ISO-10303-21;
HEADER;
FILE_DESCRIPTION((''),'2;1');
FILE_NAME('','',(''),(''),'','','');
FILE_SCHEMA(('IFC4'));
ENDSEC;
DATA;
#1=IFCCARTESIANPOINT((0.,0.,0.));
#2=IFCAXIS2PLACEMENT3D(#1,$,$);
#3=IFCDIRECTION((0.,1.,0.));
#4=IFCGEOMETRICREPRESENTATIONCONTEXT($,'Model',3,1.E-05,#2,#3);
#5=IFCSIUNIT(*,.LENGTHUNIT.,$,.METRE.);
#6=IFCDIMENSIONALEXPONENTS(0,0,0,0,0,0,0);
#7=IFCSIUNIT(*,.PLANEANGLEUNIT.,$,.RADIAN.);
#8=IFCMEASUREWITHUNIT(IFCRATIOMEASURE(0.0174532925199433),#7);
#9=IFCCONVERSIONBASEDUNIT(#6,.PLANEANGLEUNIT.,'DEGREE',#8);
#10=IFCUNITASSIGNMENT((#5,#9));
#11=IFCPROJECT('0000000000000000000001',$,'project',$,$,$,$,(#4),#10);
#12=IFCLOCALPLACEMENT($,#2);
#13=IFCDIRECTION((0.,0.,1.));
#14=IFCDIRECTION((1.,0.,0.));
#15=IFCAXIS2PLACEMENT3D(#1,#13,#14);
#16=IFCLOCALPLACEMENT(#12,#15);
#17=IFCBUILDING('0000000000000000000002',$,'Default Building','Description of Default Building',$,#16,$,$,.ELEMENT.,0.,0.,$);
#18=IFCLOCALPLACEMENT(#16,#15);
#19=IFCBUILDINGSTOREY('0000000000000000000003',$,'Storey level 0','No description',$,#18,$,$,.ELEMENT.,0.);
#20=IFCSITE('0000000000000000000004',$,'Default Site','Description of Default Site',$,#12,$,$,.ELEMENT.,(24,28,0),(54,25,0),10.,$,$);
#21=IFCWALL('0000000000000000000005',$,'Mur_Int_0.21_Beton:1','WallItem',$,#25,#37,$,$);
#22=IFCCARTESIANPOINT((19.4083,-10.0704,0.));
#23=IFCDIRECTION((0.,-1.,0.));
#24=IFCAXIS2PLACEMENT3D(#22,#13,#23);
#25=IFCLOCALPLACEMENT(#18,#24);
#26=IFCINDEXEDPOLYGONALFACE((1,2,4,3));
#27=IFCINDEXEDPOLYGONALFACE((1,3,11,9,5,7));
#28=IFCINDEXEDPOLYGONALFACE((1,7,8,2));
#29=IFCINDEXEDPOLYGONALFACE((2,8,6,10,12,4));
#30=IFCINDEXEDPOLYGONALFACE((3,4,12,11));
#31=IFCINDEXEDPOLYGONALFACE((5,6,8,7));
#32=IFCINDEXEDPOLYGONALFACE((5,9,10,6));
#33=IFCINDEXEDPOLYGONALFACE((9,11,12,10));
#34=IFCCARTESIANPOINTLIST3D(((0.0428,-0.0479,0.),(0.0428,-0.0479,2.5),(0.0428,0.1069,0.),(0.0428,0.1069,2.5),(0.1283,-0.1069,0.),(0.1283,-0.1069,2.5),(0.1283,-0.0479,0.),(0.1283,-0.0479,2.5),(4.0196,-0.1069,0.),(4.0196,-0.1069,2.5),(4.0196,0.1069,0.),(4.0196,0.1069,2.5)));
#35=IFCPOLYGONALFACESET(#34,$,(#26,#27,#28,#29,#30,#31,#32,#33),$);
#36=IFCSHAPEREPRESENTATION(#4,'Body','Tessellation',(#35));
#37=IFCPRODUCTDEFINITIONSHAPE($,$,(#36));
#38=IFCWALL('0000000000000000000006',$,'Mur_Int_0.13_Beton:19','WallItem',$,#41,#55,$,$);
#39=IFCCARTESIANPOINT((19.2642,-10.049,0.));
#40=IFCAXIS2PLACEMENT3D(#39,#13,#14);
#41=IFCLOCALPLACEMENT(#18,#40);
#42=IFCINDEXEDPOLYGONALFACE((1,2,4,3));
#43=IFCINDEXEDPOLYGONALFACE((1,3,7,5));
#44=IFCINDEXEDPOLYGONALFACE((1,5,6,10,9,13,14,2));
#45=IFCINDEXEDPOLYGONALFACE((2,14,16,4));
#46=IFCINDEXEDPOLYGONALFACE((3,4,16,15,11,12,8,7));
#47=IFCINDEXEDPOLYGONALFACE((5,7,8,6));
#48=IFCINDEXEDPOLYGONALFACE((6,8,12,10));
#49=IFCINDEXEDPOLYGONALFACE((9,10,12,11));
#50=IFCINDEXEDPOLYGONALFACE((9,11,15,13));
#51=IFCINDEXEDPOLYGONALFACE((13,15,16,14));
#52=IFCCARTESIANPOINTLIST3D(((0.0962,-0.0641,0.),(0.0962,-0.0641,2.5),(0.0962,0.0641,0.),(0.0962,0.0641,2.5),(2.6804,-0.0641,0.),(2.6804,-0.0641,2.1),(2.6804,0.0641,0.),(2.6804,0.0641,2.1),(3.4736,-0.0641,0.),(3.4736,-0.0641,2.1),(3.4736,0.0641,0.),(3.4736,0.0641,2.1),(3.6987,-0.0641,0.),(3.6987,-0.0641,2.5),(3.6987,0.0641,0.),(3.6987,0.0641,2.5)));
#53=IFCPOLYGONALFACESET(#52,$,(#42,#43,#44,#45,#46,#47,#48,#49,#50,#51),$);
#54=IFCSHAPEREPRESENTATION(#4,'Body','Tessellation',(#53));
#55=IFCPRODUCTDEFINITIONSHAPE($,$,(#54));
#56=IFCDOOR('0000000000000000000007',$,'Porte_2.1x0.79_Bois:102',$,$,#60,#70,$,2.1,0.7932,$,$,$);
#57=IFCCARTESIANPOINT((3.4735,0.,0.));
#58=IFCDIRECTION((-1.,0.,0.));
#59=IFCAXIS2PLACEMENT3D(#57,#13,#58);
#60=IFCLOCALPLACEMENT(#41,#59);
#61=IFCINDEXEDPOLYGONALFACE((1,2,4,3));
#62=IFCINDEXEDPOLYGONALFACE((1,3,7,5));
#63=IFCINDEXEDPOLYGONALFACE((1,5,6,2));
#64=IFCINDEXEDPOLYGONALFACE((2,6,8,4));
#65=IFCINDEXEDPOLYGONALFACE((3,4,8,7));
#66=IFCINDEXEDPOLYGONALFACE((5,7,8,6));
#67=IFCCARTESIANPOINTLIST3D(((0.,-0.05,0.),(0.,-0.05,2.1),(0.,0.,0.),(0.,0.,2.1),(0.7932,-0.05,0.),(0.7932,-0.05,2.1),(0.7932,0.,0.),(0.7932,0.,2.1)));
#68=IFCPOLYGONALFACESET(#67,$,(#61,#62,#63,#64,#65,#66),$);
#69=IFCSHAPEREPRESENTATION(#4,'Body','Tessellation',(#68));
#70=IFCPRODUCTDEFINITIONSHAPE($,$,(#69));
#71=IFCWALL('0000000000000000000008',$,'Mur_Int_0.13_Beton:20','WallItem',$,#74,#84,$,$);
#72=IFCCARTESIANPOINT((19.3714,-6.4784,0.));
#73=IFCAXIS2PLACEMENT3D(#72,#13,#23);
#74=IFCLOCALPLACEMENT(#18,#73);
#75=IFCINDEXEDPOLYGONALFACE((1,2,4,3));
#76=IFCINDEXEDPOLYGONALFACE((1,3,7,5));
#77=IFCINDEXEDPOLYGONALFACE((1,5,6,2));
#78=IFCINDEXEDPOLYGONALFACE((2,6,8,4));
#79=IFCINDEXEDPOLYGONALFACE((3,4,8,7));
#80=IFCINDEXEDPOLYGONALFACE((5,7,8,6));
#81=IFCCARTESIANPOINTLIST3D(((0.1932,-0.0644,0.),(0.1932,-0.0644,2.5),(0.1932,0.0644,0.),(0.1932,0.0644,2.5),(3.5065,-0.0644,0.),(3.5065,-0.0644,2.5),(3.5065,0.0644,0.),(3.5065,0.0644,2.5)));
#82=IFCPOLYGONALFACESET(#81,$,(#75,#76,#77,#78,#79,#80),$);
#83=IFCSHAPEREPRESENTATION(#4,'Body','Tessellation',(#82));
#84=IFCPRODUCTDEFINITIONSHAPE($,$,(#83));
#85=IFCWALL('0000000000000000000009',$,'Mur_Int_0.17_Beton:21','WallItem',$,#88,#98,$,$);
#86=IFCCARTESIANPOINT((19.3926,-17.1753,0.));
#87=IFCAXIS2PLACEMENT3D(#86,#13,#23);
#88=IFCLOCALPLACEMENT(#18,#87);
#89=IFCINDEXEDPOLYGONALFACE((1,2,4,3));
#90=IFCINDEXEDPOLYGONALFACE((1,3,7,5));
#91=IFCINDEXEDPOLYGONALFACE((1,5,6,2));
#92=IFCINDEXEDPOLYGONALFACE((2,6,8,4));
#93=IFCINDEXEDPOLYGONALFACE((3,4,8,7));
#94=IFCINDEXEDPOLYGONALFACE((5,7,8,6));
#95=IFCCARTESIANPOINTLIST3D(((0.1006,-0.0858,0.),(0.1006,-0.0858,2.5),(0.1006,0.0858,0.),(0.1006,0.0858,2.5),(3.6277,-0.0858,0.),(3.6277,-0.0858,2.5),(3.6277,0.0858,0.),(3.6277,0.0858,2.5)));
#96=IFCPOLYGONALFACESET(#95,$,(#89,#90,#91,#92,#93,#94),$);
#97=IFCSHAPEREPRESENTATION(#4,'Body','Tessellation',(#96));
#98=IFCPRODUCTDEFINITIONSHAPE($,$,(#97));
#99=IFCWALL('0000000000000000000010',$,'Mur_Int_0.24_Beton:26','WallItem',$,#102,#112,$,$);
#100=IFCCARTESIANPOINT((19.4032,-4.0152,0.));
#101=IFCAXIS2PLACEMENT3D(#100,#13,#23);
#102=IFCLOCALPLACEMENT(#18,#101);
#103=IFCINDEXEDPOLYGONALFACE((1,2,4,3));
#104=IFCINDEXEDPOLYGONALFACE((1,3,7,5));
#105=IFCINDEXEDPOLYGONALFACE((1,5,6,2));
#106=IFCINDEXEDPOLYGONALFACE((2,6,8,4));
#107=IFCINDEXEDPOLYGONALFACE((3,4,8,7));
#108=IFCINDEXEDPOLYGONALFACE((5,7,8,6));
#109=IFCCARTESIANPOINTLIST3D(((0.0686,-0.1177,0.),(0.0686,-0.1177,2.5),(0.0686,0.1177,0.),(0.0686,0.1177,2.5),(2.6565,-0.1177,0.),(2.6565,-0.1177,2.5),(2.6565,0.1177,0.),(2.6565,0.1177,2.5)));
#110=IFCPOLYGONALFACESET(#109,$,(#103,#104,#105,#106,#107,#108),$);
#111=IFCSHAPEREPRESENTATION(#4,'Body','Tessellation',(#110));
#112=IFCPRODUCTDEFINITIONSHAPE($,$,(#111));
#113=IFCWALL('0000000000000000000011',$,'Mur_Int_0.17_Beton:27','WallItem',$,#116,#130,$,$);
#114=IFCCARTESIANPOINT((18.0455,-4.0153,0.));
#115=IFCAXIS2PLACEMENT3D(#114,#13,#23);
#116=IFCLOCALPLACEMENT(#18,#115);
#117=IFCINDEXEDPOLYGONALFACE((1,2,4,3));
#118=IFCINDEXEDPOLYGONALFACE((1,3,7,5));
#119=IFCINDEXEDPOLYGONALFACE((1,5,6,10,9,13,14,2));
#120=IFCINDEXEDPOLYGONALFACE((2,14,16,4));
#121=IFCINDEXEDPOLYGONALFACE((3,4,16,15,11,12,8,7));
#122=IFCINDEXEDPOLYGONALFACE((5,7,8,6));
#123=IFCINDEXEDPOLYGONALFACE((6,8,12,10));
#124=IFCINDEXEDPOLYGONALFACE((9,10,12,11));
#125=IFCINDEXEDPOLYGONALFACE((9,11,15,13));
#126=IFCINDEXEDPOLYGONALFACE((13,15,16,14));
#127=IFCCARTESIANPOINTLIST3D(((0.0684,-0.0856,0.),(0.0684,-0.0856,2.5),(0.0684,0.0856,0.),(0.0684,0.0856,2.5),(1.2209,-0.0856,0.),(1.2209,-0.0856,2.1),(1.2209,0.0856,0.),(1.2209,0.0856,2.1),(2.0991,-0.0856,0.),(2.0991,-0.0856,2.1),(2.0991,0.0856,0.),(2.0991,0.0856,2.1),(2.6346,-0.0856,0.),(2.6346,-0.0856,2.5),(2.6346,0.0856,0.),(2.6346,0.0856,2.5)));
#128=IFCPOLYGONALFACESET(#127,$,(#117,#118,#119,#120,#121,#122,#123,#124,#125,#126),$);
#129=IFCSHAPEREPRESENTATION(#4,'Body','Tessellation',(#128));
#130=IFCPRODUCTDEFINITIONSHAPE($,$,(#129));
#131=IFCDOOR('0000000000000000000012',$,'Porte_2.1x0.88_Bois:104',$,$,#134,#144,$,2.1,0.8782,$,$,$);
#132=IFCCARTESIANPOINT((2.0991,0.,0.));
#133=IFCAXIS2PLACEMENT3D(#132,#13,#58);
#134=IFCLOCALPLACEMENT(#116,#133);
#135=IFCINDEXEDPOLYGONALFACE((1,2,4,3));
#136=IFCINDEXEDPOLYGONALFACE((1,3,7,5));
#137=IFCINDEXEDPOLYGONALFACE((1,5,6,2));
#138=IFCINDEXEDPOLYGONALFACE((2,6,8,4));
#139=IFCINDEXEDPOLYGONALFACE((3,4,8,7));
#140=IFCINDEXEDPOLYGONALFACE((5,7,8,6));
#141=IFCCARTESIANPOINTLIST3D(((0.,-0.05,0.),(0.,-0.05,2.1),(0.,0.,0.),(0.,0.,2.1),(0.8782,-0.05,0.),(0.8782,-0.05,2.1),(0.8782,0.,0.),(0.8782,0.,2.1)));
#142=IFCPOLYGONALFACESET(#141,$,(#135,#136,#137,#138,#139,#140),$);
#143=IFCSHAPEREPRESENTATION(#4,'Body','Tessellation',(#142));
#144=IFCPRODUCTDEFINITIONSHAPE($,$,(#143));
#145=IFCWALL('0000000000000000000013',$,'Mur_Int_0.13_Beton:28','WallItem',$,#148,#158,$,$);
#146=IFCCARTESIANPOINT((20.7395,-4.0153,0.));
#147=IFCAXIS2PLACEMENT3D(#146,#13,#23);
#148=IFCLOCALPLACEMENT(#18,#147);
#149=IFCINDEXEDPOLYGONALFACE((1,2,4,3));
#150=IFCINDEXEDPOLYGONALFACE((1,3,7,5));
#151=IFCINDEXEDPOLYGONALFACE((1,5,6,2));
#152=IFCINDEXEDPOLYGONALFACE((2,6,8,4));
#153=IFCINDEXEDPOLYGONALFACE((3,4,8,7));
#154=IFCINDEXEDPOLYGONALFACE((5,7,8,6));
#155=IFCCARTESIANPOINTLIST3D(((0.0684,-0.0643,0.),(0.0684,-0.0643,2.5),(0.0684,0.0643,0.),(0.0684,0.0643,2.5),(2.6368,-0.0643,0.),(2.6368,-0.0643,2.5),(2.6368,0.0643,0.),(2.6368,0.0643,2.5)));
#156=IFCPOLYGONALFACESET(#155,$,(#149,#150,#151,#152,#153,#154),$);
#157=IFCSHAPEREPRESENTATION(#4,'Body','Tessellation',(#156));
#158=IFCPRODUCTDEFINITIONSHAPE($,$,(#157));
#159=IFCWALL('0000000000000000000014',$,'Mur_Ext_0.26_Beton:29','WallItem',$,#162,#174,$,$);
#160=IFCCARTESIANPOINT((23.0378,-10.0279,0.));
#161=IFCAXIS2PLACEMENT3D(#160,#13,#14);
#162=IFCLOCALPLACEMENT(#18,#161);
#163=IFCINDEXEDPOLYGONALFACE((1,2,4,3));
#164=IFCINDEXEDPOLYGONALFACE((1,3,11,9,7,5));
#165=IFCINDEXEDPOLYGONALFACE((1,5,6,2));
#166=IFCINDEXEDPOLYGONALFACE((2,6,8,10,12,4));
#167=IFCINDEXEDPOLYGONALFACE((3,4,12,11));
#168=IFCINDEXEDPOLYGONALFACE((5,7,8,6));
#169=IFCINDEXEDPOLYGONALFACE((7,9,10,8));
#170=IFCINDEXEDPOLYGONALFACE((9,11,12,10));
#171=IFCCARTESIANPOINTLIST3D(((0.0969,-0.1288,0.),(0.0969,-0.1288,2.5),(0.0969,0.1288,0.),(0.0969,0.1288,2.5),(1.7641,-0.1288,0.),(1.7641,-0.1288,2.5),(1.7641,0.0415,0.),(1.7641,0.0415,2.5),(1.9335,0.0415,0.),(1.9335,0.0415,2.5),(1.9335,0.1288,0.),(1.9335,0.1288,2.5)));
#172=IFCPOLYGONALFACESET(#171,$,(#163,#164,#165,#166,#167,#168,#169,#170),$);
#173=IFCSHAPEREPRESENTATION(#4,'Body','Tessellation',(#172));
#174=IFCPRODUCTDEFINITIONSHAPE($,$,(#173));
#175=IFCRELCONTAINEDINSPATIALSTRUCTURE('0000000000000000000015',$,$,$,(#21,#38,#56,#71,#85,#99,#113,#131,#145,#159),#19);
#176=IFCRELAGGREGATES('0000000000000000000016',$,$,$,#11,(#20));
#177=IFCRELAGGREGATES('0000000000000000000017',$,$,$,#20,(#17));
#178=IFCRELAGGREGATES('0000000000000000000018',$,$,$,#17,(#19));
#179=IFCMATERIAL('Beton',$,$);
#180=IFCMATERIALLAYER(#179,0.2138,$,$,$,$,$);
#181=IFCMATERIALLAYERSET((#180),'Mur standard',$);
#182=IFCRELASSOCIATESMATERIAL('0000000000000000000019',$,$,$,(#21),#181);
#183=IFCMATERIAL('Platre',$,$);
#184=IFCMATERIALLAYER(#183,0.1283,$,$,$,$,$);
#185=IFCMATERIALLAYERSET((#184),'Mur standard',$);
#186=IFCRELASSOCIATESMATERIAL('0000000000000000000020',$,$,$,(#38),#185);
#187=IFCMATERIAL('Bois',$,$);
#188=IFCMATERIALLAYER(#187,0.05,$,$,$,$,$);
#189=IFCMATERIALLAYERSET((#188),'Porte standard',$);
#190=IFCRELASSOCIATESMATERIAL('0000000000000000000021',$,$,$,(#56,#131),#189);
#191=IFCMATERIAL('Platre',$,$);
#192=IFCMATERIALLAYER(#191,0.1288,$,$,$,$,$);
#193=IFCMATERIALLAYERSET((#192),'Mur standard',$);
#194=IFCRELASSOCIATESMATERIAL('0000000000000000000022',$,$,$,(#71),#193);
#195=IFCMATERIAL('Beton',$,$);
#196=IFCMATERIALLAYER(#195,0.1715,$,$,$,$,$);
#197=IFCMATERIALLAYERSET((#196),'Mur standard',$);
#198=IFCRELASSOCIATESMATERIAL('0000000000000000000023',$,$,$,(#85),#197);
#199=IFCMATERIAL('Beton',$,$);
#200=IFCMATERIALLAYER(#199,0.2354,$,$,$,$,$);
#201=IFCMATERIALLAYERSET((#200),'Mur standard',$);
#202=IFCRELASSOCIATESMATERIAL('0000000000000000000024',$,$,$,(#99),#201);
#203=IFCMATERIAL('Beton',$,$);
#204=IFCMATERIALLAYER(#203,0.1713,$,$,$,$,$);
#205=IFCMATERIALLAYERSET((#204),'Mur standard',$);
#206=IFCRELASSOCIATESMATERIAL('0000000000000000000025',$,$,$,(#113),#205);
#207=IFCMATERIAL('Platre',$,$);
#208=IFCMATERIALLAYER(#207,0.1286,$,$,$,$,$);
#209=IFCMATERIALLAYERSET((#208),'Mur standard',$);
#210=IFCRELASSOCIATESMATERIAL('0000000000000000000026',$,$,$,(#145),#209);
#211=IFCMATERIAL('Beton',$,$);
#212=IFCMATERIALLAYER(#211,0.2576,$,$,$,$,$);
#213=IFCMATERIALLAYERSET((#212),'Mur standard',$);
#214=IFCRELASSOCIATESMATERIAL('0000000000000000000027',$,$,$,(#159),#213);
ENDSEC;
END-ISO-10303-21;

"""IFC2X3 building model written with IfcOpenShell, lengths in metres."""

from ifc_helpers import new_model, entity, si_unit, converted_unit, direction, frame, origin, origin_with_axes, place, context, project, spatial, polyline, outline, extrude, material, layer, layer_set, layer_usage, element, fill, save


model = new_model("IFC2X3")

# Units and contexts
model_context = context("Model", 3, precision=1e-05, world=origin(), true_north=direction((0.0, 1.0, 0.0)))
ifc_project = project(units=[si_unit("LENGTHUNIT", "METRE"), converted_unit("PLANEANGLEUNIT", "DEGREE", entity("IfcRatioMeasure", 0.0174532925199433), si_unit("PLANEANGLEUNIT", "RADIAN"), dimensions=[0, 0, 0, 0, 0, 0, 0])], contexts=[model_context])

# Site, building, storey
site_placement = place(None, origin())
site = spatial("IfcSite", under=ifc_project, at=site_placement, Name="Default Site", Description="Description of Default Site", CompositionType="ELEMENT", RefLatitude=(24, 28, 0), RefLongitude=(54, 25, 0), RefElevation=10.0)
building_placement = place(site_placement, origin_with_axes())
building = spatial("IfcBuilding", under=site, at=building_placement, Name="Default Building", Description="Description of Default Building", CompositionType="ELEMENT", ElevationOfRefHeight=0.0, ElevationOfTerrain=0.0)
storey_placement = place(building_placement, origin_with_axes())
storey = spatial("IfcBuildingStorey", under=building, at=storey_placement, Name="Storey level 0", Description="No description", CompositionType="ELEMENT", Elevation=0.0)

# Wall
ifc_material_1 = material(Name="Beton")
ifc_layer_1 = layer(ifc_material_1, 0.2138)
ifc_layer_set_1 = layer_set([ifc_layer_1], Name="Mur standard")
ifc_layer_usage_1 = layer_usage(ifc_layer_set_1, "AXIS2", "NEGATIVE", 0.2138)
wall_1_placement = place(storey_placement, frame((19.4083, -10.0704, 0.0), z_axis=(0.0, 0.0, 1.0), x_axis=(0.0, -1.0, 0.0)))
element("IfcWall", 1, at=wall_1_placement, inside=storey, material=ifc_layer_usage_1, Name="Mur_Int_0.21_Beton:1", Description="WallItem", context=model_context, shape_type="SweptSolid", body=[
    extrude(outline(polyline([(4.0196, 0.1069), (4.0196, -0.1069), (0.1283, -0.1069), (0.1283, -0.0479), (0.0428, -0.0479), (0.0428, 0.1069), (4.0196, 0.1069)])), origin(), (0.0, 0.0, 1.0), 2.5),
])

# Shared definitions
ifc_material_2 = material(Name="Bois")
ifc_layer_2 = layer(ifc_material_2, 0.05)
ifc_layer_set_2 = layer_set([ifc_layer_2], Name="Porte standard")
ifc_layer_usage_2 = layer_usage(ifc_layer_set_2, "AXIS2", "NEGATIVE", 0.05)

# Wall, opening, door
ifc_material_3 = material(Name="Platre")
ifc_layer_3 = layer(ifc_material_3, 0.1283)
ifc_layer_set_3 = layer_set([ifc_layer_3], Name="Mur standard")
ifc_layer_usage_3 = layer_usage(ifc_layer_set_3, "AXIS2", "NEGATIVE", 0.1283)
wall_2_placement = place(storey_placement, frame((19.2642, -10.049, 0.0), z_axis=(0.0, 0.0, 1.0), x_axis=(1.0, 0.0, 0.0)))
wall_2 = element("IfcWall", 2, at=wall_2_placement, inside=storey, material=ifc_layer_usage_3, Name="Mur_Int_0.13_Beton:19", Description="WallItem", context=model_context, shape_type="SweptSolid", body=[
    extrude(outline(polyline([(0.0962, 0.0641), (0.0962, -0.0641), (3.6987, -0.0641), (3.6987, 0.0641), (0.0962, 0.0641)])), origin(), (0.0, 0.0, 1.0), 2.5),
])
opening_1_placement = place(storey_placement, frame((22.7378, -9.9849, 0.0), z_axis=(0.0, 0.0, 1.0), x_axis=(-1.0, 0.0, 0.0)))
opening_1 = element("IfcOpeningElement", 3, at=opening_1_placement, cuts=wall_2, context=model_context, shape_type="SweptSolid", body=[
    extrude(outline(polyline([(0.7932, 0.1783), (0.0, 0.1783), (0.0, -0.05), (0.7932, -0.05), (0.7932, 0.1783)])), origin(), (0.0, 0.0, 1.0), 2.1),
])
door_1_placement = place(wall_2_placement, frame((3.4735, 0.0, 0.0), z_axis=(0.0, 0.0, 1.0), x_axis=(-1.0, 0.0, 0.0)))
door_1 = element("IfcDoor", 4, at=door_1_placement, inside=storey, material=ifc_layer_usage_2, Name="Porte_2.1x0.79_Bois:102", OverallHeight=2.1, OverallWidth=0.7932, context=model_context, shape_type="SweptSolid", body=[
    extrude(outline(polyline([(0.0, 0.0), (0.7932, 0.0), (0.7932, -0.05), (0.0, -0.05), (0.0, 0.0)])), origin(), (0.0, 0.0, 1.0), 2.1),
])
fill(opening_1, door_1)

# Walls
ifc_material_4 = material(Name="Platre")
ifc_layer_4 = layer(ifc_material_4, 0.1288)
ifc_layer_set_4 = layer_set([ifc_layer_4], Name="Mur standard")
ifc_layer_usage_4 = layer_usage(ifc_layer_set_4, "AXIS2", "NEGATIVE", 0.1288)
wall_3_placement = place(storey_placement, frame((19.3714, -6.4784, 0.0), z_axis=(0.0, 0.0, 1.0), x_axis=(0.0, -1.0, 0.0)))
element("IfcWall", 5, at=wall_3_placement, inside=storey, material=ifc_layer_usage_4, Name="Mur_Int_0.13_Beton:20", Description="WallItem", context=model_context, shape_type="SweptSolid", body=[
    extrude(outline(polyline([(0.1932, -0.0644), (3.5065, -0.0644), (3.5065, 0.0644), (0.1932, 0.0644), (0.1932, -0.0644)])), origin(), (0.0, 0.0, 1.0), 2.5),
])
ifc_material_5 = material(Name="Beton")
ifc_layer_5 = layer(ifc_material_5, 0.1715)
ifc_layer_set_5 = layer_set([ifc_layer_5], Name="Mur standard")
ifc_layer_usage_5 = layer_usage(ifc_layer_set_5, "AXIS2", "NEGATIVE", 0.1715)
wall_4_placement = place(storey_placement, frame((19.3926, -17.1753, 0.0), z_axis=(0.0, 0.0, 1.0), x_axis=(0.0, -1.0, 0.0)))
element("IfcWall", 6, at=wall_4_placement, inside=storey, material=ifc_layer_usage_5, Name="Mur_Int_0.17_Beton:21", Description="WallItem", context=model_context, shape_type="SweptSolid", body=[
    extrude(outline(polyline([(0.1006, -0.0858), (3.6277, -0.0858), (3.6277, 0.0858), (0.1006, 0.0858), (0.1006, -0.0858)])), origin(), (0.0, 0.0, 1.0), 2.5),
])
ifc_material_6 = material(Name="Beton")
ifc_layer_6 = layer(ifc_material_6, 0.2354)
ifc_layer_set_6 = layer_set([ifc_layer_6], Name="Mur standard")
ifc_layer_usage_6 = layer_usage(ifc_layer_set_6, "AXIS2", "NEGATIVE", 0.2354)
wall_5_placement = place(storey_placement, frame((19.4032, -4.0152, 0.0), z_axis=(0.0, 0.0, 1.0), x_axis=(0.0, -1.0, 0.0)))
element("IfcWall", 7, at=wall_5_placement, inside=storey, material=ifc_layer_usage_6, Name="Mur_Int_0.24_Beton:26", Description="WallItem", context=model_context, shape_type="SweptSolid", body=[
    extrude(outline(polyline([(0.0686, -0.1177), (2.6565, -0.1177), (2.6565, 0.1177), (0.0686, 0.1177), (0.0686, -0.1177)])), origin(), (0.0, 0.0, 1.0), 2.5),
])

# Wall, opening, door
ifc_material_7 = material(Name="Beton")
ifc_layer_7 = layer(ifc_material_7, 0.1713)
ifc_layer_set_7 = layer_set([ifc_layer_7], Name="Mur standard")
ifc_layer_usage_7 = layer_usage(ifc_layer_set_7, "AXIS2", "NEGATIVE", 0.1713)
wall_6_placement = place(storey_placement, frame((18.0455, -4.0153, 0.0), z_axis=(0.0, 0.0, 1.0), x_axis=(0.0, -1.0, 0.0)))
wall_6 = element("IfcWall", 8, at=wall_6_placement, inside=storey, material=ifc_layer_usage_7, Name="Mur_Int_0.17_Beton:27", Description="WallItem", context=model_context, shape_type="SweptSolid", body=[
    extrude(outline(polyline([(0.0684, -0.0856), (2.6346, -0.0856), (2.6346, 0.0856), (0.0684, 0.0856), (0.0684, -0.0856)])), origin(), (0.0, 0.0, 1.0), 2.5),
])
opening_2_placement = place(storey_placement, frame((17.9599, -6.1144, 0.0), z_axis=(0.0, 0.0, 1.0), x_axis=(0.0, 1.0, 0.0)))
opening_2 = element("IfcOpeningElement", 9, at=opening_2_placement, cuts=wall_6, context=model_context, shape_type="SweptSolid", body=[
    extrude(outline(polyline([(0.8782, 0.05), (0.0, 0.05), (0.0, -0.2213), (0.8782, -0.2213), (0.8782, 0.05)])), origin(), (0.0, 0.0, 1.0), 2.1),
])
door_2_placement = place(wall_6_placement, frame((2.0991, 0.0, 0.0), z_axis=(0.0, 0.0, 1.0), x_axis=(-1.0, 0.0, 0.0)))
door_2 = element("IfcDoor", 10, at=door_2_placement, inside=storey, material=ifc_layer_usage_2, Name="Porte_2.1x0.88_Bois:104", OverallHeight=2.1, OverallWidth=0.8782, context=model_context, shape_type="SweptSolid", body=[
    extrude(outline(polyline([(0.0, 0.0), (0.8782, 0.0), (0.8782, -0.05), (0.0, -0.05), (0.0, 0.0)])), origin(), (0.0, 0.0, 1.0), 2.1),
])
fill(opening_2, door_2)

# Walls
ifc_material_8 = material(Name="Platre")
ifc_layer_8 = layer(ifc_material_8, 0.1286)
ifc_layer_set_8 = layer_set([ifc_layer_8], Name="Mur standard")
ifc_layer_usage_8 = layer_usage(ifc_layer_set_8, "AXIS2", "NEGATIVE", 0.1286)
wall_7_placement = place(storey_placement, frame((20.7395, -4.0153, 0.0), z_axis=(0.0, 0.0, 1.0), x_axis=(0.0, -1.0, 0.0)))
element("IfcWall", 11, at=wall_7_placement, inside=storey, material=ifc_layer_usage_8, Name="Mur_Int_0.13_Beton:28", Description="WallItem", context=model_context, shape_type="SweptSolid", body=[
    extrude(outline(polyline([(0.0684, -0.0643), (2.6368, -0.0643), (2.6368, 0.0643), (0.0684, 0.0643), (0.0684, -0.0643)])), origin(), (0.0, 0.0, 1.0), 2.5),
])
ifc_material_9 = material(Name="Beton")
ifc_layer_9 = layer(ifc_material_9, 0.2576)
ifc_layer_set_9 = layer_set([ifc_layer_9], Name="Mur standard")
ifc_layer_usage_9 = layer_usage(ifc_layer_set_9, "AXIS2", "NEGATIVE", 0.2576)
wall_8_placement = place(storey_placement, frame((23.0378, -10.0279, 0.0), z_axis=(0.0, 0.0, 1.0), x_axis=(1.0, 0.0, 0.0)))
element("IfcWall", 12, at=wall_8_placement, inside=storey, material=ifc_layer_usage_9, Name="Mur_Ext_0.26_Beton:29", Description="WallItem", context=model_context, shape_type="SweptSolid", body=[
    extrude(outline(polyline([(1.9335, 0.0415), (1.7641, 0.0415), (1.7641, -0.1288), (0.0969, -0.1288), (0.0969, 0.1288), (1.9335, 0.1288), (1.9335, 0.0415)])), origin(), (0.0, 0.0, 1.0), 2.5),
])

save(model, "model.ifc")
